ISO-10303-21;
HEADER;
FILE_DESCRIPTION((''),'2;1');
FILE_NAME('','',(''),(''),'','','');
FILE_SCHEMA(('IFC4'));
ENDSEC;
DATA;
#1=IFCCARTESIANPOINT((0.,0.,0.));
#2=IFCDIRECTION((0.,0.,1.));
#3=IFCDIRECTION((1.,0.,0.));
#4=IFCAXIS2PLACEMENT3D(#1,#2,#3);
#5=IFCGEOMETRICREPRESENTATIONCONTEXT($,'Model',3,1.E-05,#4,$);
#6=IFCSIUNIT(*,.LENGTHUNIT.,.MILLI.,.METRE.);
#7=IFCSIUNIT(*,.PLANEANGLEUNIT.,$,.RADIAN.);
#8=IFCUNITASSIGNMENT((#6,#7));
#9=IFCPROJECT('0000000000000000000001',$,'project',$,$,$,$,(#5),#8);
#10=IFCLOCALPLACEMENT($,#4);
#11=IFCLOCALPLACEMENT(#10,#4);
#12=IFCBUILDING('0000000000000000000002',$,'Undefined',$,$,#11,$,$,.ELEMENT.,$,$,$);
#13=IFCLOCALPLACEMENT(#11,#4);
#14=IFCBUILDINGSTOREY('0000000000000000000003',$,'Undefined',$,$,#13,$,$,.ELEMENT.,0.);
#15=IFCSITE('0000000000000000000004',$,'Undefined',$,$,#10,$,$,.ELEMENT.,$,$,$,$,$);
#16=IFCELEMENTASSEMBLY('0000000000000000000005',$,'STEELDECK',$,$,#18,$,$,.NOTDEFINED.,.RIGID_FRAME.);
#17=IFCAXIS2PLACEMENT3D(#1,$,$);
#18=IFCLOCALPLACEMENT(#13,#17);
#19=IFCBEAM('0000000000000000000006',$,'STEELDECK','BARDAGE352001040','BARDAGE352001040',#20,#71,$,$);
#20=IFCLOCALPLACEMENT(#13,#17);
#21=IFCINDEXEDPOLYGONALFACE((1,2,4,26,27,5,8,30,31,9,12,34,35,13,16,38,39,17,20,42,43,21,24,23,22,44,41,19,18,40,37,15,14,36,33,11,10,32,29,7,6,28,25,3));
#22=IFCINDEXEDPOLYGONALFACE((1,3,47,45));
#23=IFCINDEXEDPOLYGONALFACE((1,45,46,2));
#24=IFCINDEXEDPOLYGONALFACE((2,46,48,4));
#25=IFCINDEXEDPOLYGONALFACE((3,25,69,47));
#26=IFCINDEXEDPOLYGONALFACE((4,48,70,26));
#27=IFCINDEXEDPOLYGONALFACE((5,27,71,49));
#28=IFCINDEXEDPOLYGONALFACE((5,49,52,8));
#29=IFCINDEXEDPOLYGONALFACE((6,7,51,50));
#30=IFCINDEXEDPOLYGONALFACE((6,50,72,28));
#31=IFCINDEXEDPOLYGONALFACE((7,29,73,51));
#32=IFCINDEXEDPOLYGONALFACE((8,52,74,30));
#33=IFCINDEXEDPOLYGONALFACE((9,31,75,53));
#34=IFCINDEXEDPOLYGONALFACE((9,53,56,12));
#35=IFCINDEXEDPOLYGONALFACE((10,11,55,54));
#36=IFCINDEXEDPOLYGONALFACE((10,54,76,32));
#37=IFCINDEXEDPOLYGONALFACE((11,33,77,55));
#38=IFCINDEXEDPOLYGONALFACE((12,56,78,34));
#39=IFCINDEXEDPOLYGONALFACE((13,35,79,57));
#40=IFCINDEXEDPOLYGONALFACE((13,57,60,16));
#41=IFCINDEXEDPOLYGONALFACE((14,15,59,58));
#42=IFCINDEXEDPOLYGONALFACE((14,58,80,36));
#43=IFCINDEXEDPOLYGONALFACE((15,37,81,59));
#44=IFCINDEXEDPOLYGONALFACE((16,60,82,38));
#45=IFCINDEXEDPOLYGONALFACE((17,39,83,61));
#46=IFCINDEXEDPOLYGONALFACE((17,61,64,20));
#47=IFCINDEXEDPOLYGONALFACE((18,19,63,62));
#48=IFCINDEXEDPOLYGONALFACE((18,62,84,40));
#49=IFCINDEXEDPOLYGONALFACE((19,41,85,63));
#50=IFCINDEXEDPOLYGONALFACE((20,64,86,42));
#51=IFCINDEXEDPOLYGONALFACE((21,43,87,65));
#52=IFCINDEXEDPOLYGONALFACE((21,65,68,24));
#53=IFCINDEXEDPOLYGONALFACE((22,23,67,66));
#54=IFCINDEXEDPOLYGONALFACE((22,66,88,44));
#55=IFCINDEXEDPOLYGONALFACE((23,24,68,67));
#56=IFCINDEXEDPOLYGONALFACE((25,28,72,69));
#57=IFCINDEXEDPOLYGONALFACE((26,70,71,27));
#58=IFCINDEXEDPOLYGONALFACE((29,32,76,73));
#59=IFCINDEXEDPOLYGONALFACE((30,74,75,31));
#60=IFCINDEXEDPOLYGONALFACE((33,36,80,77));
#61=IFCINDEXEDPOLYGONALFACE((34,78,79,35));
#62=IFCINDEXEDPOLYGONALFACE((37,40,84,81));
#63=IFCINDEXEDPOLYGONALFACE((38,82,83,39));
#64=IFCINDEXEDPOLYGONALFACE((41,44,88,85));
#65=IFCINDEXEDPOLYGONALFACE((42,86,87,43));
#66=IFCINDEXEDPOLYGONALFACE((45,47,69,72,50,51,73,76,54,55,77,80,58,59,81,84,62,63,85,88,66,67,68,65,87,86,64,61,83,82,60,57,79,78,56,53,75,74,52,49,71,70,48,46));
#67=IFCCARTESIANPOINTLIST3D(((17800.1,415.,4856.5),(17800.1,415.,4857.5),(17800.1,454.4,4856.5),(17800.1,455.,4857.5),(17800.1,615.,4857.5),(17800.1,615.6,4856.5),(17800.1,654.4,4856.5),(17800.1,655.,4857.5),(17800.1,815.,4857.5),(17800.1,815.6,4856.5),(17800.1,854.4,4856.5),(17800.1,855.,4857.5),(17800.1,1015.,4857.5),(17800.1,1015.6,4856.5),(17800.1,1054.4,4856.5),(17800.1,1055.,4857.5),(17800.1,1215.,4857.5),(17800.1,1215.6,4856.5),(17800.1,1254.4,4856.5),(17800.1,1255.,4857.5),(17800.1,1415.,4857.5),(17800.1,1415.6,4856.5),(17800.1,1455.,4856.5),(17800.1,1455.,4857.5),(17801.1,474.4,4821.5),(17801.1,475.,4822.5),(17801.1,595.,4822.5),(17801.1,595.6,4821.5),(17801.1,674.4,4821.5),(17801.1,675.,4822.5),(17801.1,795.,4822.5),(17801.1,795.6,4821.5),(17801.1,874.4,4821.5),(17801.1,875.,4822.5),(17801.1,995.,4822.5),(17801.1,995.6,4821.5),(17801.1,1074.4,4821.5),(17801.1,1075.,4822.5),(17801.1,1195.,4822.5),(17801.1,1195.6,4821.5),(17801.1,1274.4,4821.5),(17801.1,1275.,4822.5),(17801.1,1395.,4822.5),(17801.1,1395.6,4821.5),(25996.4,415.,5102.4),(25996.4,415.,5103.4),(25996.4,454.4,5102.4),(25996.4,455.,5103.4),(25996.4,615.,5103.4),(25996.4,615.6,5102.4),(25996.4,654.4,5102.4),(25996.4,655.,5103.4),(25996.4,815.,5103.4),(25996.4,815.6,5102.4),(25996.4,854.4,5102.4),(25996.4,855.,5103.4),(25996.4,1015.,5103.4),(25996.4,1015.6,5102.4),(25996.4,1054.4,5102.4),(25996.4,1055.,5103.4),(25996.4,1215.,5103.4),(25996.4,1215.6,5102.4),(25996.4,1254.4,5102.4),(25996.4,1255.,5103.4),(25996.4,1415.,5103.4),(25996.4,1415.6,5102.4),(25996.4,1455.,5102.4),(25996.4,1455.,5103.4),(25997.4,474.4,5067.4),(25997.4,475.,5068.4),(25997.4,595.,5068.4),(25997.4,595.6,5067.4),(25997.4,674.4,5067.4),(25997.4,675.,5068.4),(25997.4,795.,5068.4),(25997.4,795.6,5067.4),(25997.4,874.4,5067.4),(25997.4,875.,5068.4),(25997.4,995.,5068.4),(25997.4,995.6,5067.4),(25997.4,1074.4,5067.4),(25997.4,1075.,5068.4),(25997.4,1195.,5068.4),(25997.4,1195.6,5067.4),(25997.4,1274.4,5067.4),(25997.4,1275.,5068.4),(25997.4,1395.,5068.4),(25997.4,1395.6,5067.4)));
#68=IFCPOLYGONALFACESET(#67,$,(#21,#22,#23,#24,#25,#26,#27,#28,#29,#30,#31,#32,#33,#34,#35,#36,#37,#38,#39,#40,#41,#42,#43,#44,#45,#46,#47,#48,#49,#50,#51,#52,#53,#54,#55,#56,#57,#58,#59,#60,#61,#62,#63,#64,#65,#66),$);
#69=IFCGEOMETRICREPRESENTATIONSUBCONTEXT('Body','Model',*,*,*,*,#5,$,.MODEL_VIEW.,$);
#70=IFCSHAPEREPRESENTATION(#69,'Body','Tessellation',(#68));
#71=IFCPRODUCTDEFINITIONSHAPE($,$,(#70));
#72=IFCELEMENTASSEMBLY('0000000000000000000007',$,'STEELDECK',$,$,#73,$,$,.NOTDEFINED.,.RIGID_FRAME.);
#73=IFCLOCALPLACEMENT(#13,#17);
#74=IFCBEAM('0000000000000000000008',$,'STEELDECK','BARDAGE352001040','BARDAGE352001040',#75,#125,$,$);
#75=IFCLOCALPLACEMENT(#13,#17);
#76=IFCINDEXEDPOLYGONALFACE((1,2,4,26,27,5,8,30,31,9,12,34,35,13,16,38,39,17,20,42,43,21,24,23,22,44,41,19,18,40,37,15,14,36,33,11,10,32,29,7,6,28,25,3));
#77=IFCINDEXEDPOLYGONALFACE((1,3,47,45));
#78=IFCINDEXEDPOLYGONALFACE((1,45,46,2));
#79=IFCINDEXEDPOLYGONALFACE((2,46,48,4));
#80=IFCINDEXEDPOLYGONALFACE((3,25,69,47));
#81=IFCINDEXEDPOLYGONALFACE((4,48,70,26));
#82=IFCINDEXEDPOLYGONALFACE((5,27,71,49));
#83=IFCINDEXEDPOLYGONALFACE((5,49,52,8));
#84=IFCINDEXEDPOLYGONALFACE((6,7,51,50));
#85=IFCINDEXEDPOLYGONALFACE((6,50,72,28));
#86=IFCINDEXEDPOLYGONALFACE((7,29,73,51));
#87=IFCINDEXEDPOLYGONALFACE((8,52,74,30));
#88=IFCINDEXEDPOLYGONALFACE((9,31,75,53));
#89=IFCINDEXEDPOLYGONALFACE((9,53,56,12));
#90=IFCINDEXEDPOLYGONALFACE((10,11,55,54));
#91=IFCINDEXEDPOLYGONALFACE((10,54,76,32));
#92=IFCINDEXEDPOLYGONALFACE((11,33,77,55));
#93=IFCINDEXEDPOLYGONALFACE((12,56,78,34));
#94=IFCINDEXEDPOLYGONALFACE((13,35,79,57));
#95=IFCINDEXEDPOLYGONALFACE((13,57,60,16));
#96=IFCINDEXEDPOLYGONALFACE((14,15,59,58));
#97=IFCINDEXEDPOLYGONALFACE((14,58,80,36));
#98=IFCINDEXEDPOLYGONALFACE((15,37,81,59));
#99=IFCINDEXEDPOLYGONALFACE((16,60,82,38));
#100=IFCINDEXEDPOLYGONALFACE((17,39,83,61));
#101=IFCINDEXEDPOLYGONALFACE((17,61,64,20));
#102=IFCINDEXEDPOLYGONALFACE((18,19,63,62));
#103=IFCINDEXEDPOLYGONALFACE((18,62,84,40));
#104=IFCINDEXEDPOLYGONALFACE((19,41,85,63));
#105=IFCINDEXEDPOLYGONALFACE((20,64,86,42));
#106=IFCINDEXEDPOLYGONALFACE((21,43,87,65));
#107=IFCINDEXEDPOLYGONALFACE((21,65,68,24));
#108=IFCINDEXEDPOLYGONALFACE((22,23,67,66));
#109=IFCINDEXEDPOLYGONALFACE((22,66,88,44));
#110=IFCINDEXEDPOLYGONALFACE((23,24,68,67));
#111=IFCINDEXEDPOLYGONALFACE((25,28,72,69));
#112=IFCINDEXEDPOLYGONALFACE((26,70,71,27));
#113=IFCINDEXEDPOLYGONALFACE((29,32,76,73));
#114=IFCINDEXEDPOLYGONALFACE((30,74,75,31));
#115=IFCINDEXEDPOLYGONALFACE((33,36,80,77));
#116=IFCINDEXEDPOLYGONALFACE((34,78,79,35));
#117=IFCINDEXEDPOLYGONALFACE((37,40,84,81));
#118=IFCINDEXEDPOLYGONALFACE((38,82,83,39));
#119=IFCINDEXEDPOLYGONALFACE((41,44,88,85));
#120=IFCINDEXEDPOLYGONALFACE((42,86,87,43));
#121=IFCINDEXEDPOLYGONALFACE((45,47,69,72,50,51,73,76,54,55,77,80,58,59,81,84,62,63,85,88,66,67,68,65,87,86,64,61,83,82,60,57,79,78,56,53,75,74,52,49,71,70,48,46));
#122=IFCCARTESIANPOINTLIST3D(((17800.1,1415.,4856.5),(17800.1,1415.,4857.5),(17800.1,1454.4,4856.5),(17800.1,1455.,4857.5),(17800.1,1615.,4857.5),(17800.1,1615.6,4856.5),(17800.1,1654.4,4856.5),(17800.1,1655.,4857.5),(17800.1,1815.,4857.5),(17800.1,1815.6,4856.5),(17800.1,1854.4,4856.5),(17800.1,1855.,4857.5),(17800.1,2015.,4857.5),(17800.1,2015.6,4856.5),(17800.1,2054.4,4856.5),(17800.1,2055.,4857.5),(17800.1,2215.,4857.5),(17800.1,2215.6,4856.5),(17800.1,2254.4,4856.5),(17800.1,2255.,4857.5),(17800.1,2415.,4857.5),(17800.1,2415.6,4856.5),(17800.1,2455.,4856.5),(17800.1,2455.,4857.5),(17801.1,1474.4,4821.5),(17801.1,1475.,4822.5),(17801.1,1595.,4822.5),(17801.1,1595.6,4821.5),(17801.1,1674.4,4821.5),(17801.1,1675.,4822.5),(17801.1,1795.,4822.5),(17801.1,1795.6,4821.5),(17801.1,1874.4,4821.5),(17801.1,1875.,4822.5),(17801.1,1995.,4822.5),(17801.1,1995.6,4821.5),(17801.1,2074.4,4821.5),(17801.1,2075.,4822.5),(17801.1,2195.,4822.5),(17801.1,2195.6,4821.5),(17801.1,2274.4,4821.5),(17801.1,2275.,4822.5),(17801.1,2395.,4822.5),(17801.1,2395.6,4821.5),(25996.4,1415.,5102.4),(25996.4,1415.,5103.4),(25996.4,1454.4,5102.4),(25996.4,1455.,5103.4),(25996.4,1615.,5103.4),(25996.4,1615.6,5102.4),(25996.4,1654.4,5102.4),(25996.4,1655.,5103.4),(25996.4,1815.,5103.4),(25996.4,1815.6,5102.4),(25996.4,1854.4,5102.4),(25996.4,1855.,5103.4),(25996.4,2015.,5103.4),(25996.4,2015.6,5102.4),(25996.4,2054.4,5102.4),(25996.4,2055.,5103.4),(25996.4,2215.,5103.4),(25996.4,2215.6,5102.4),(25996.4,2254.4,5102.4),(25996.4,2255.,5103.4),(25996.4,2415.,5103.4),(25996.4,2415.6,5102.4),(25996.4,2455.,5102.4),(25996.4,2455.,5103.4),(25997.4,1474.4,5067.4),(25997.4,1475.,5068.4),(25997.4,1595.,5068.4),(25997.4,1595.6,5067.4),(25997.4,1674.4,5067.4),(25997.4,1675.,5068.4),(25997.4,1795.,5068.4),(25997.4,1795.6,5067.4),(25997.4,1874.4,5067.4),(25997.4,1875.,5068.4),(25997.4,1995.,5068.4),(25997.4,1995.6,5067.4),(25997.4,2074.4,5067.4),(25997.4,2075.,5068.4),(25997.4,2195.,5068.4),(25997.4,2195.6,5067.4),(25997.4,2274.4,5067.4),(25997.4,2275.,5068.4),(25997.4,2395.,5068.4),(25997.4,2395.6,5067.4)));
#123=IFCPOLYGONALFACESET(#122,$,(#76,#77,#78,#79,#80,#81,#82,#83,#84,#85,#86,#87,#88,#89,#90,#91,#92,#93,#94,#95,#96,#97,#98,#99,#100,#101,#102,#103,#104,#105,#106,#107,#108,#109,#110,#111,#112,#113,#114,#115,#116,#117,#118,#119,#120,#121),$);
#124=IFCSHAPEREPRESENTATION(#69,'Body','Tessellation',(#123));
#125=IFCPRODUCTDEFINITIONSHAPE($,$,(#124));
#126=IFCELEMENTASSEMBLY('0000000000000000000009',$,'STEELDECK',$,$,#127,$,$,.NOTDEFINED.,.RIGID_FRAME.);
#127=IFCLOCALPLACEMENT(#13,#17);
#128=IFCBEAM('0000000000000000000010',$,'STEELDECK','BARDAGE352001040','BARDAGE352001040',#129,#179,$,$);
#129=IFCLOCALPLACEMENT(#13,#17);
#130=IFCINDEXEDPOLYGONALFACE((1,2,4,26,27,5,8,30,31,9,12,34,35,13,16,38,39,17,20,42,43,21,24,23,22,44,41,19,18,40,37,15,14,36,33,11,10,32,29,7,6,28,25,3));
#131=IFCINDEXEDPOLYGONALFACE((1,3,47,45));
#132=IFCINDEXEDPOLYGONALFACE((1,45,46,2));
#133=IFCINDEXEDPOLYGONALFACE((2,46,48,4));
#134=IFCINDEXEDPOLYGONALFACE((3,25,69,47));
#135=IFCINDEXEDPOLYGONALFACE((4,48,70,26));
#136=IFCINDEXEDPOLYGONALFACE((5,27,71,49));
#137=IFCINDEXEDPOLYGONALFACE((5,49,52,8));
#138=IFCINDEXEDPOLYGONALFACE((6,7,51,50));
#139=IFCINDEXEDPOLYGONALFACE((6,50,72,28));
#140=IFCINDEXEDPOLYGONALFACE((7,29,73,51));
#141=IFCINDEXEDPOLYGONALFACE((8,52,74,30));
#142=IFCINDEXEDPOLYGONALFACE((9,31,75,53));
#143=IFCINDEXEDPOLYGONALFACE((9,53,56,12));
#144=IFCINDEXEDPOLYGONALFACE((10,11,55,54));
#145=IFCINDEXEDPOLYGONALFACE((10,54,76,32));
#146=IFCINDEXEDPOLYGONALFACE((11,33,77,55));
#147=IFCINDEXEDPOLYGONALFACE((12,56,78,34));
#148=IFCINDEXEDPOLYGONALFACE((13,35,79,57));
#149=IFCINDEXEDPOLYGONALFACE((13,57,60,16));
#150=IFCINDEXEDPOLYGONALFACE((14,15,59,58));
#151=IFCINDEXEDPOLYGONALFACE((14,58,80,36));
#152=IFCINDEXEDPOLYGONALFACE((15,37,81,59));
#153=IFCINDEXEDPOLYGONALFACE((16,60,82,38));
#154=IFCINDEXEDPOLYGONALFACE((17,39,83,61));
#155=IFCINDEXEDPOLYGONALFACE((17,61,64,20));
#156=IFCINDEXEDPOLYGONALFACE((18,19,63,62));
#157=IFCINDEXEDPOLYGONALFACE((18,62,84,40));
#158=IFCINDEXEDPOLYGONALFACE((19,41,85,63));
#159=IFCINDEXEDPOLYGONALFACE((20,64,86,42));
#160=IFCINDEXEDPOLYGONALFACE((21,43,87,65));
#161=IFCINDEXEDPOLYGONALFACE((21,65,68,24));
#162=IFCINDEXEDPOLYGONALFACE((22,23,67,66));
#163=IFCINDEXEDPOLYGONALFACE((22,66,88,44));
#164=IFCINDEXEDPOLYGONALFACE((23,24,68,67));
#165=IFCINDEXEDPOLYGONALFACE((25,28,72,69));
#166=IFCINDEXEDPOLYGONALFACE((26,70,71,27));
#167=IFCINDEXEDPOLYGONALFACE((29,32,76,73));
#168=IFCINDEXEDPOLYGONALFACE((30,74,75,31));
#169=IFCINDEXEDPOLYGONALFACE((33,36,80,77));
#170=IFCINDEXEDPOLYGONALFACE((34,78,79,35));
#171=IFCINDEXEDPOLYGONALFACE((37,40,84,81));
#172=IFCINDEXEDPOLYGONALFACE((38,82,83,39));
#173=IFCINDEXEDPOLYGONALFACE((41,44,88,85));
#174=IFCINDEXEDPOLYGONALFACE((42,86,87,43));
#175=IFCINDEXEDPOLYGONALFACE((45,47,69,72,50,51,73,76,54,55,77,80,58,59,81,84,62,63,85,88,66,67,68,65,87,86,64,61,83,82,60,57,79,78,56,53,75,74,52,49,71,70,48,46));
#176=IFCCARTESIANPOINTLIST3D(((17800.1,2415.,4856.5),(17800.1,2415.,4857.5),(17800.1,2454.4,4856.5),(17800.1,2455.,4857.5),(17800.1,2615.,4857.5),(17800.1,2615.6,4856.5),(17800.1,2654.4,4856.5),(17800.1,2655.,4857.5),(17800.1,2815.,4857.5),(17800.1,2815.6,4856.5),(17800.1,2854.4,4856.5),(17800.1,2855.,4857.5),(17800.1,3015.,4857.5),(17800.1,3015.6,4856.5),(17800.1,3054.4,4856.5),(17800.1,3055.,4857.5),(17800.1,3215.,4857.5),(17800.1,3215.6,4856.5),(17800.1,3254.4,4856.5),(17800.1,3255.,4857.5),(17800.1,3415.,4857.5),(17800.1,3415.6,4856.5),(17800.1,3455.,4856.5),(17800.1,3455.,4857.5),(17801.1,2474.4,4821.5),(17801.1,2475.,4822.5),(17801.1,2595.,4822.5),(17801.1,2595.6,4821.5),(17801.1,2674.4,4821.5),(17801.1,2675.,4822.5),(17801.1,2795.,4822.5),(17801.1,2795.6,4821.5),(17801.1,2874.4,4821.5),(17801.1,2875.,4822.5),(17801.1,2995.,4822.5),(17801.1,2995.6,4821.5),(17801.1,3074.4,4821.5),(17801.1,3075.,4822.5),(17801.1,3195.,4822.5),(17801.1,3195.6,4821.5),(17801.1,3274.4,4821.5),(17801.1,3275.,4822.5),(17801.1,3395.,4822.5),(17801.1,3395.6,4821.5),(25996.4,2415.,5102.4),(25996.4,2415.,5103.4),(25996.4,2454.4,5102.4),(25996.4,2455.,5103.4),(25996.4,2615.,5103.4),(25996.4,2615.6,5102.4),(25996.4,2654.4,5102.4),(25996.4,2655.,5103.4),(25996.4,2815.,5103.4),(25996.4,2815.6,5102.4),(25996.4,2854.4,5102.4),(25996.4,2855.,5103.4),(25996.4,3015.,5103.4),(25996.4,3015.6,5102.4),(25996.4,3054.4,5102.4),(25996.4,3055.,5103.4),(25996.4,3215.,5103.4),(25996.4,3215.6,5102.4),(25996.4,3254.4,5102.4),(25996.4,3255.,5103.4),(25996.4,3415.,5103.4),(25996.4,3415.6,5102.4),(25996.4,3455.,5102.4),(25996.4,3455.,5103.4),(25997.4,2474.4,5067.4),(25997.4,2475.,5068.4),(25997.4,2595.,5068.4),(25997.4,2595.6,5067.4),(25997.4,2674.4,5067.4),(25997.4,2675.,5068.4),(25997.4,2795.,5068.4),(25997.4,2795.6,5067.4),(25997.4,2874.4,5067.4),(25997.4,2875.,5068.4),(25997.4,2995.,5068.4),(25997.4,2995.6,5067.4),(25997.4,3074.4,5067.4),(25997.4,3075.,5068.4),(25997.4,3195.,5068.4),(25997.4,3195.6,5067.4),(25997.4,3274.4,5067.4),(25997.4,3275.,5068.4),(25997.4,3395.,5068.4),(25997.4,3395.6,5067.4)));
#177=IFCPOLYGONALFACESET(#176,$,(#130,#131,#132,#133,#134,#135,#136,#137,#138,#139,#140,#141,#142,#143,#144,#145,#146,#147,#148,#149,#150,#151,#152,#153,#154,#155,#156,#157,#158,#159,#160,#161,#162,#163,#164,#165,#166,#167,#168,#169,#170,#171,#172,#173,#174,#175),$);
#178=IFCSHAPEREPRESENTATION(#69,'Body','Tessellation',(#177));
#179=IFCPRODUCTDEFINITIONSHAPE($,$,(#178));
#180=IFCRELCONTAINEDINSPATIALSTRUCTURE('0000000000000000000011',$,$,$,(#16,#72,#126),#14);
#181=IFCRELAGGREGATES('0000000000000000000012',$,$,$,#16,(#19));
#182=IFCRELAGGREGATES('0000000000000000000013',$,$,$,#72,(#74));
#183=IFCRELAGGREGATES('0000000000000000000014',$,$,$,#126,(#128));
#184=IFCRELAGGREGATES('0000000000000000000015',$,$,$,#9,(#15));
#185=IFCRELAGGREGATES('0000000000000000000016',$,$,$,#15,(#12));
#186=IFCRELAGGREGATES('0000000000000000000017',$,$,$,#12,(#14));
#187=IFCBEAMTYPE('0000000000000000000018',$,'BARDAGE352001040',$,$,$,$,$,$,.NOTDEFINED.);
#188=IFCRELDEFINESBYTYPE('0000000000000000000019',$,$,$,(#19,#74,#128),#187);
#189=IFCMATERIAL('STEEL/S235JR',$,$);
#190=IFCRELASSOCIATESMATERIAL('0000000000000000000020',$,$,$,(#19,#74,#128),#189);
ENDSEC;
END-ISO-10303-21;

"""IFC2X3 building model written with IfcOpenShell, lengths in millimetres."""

from ifc_helpers import new_model, si_unit, frame, origin_with_axes, place, context, subcontext, project, spatial, polyline, outline, extrude, material, type_object, element, aggregate, save


model = new_model("IFC2X3")

# Units and contexts
model_context = context("Model", 3, precision=1e-05, world=origin_with_axes())
body_context = subcontext(model_context, "Body", "Model", "MODEL_VIEW")
ifc_project = project(units=[si_unit("LENGTHUNIT", "METRE", prefix="MILLI"), si_unit("PLANEANGLEUNIT", "RADIAN")], contexts=[model_context])

# Site, building, storey
site_placement = place(None, origin_with_axes())
site = spatial("IfcSite", under=ifc_project, at=site_placement, Name="Undefined", CompositionType="ELEMENT")
building_placement = place(site_placement, origin_with_axes())
building = spatial("IfcBuilding", under=site, at=building_placement, Name="Undefined", CompositionType="ELEMENT")
storey_placement = place(building_placement, origin_with_axes())
storey = spatial("IfcBuildingStorey", under=building, at=storey_placement, Name="Undefined", CompositionType="ELEMENT", Elevation=0.0)

# Element assemblies, beams
ifc_material_1 = material(Name="STEEL/S235JR")
beam_type_1 = type_object("IfcBeamType", Name="BARDAGE352001040", PredefinedType="NOTDEFINED")
assembly_1_placement = place(storey_placement, origin_with_axes())
assembly_1 = element("IfcElementAssembly", 1, at=assembly_1_placement, inside=storey, Name="STEELDECK", AssemblyPlace="NOTDEFINED", PredefinedType="RIGID_FRAME")
beam_1_placement = place(assembly_1_placement, frame((17800.1, 1455.0, 4857.5), z_axis=(-0.029987, 0.0, 0.99955), x_axis=(0.99955, 0.0, 0.029986)))
beam_1 = element("IfcBeam", 2, at=beam_1_placement, type_object=beam_type_1, material=ifc_material_1, Name="STEELDECK", Description="BARDAGE352001040", ObjectType="BARDAGE352001040", context=body_context, shape_type="SweptSolid", body=[
    extrude(outline(polyline([(200.6, -1.0), (180.6, -36.0), (59.4, -36.0), (39.4, -1.0), (0.0, -1.0), (0.0, 0.0), (40.0, 0.0), (60.0, -35.0), (180.0, -35.0), (200.0, 0.0), (240.0, 0.0), (260.0, -35.0), (380.0, -35.0), (400.0, 0.0), (440.0, 0.0), (460.0, -35.0), (580.0, -35.0), (600.0, 0.0), (640.0, 0.0), (660.0, -35.0), (780.0, -35.0), (800.0, 0.0), (840.0, 0.0), (860.0, -35.0), (980.0, -35.0), (1000.0, 0.0), (1040.0, 0.0), (1040.0, -1.0), (1000.6, -1.0), (980.6, -36.0), (859.4, -36.0), (839.4, -1.0), (800.6, -1.0), (780.6, -36.0), (659.4, -36.0), (639.4, -1.0), (600.6, -1.0), (580.6, -36.0), (459.4, -36.0), (439.4, -1.0), (400.6, -1.0), (380.6, -36.0), (259.4, -36.0), (239.4, -1.0), (200.6, -1.0)])), frame((8200.0, 0.0, 0.0), z_axis=(-1.0, 0.0, 0.0), x_axis=(0.0, -1.0, 0.0)), (0.0, 0.0, 1.0), 8200.0),
])
aggregate(assembly_1, [beam_1])
assembly_2_placement = place(storey_placement, origin_with_axes())
assembly_2 = element("IfcElementAssembly", 3, at=assembly_2_placement, inside=storey, Name="STEELDECK", AssemblyPlace="NOTDEFINED", PredefinedType="RIGID_FRAME")
beam_2_placement = place(assembly_2_placement, frame((17800.1, 2455.0, 4857.5), z_axis=(-0.029987, 0.0, 0.99955), x_axis=(0.99955, 0.0, 0.029986)))
beam_2 = element("IfcBeam", 4, at=beam_2_placement, type_object=beam_type_1, material=ifc_material_1, Name="STEELDECK", Description="BARDAGE352001040", ObjectType="BARDAGE352001040", context=body_context, shape_type="SweptSolid", body=[
    extrude(outline(polyline([(200.6, -1.0), (180.6, -36.0), (59.4, -36.0), (39.4, -1.0), (0.0, -1.0), (0.0, 0.0), (40.0, 0.0), (60.0, -35.0), (180.0, -35.0), (200.0, 0.0), (240.0, 0.0), (260.0, -35.0), (380.0, -35.0), (400.0, 0.0), (440.0, 0.0), (460.0, -35.0), (580.0, -35.0), (600.0, 0.0), (640.0, 0.0), (660.0, -35.0), (780.0, -35.0), (800.0, 0.0), (840.0, 0.0), (860.0, -35.0), (980.0, -35.0), (1000.0, 0.0), (1040.0, 0.0), (1040.0, -1.0), (1000.6, -1.0), (980.6, -36.0), (859.4, -36.0), (839.4, -1.0), (800.6, -1.0), (780.6, -36.0), (659.4, -36.0), (639.4, -1.0), (600.6, -1.0), (580.6, -36.0), (459.4, -36.0), (439.4, -1.0), (400.6, -1.0), (380.6, -36.0), (259.4, -36.0), (239.4, -1.0), (200.6, -1.0)])), frame((8200.0, 0.0, 0.0), z_axis=(-1.0, 0.0, 0.0), x_axis=(0.0, -1.0, 0.0)), (0.0, 0.0, 1.0), 8200.0),
])
aggregate(assembly_2, [beam_2])
assembly_3_placement = place(storey_placement, origin_with_axes())
assembly_3 = element("IfcElementAssembly", 5, at=assembly_3_placement, inside=storey, Name="STEELDECK", AssemblyPlace="NOTDEFINED", PredefinedType="RIGID_FRAME")
beam_3_placement = place(assembly_3_placement, frame((17800.1, 3455.0, 4857.5), z_axis=(-0.029987, 0.0, 0.99955), x_axis=(0.99955, 0.0, 0.029986)))
beam_3 = element("IfcBeam", 6, at=beam_3_placement, type_object=beam_type_1, material=ifc_material_1, Name="STEELDECK", Description="BARDAGE352001040", ObjectType="BARDAGE352001040", context=body_context, shape_type="SweptSolid", body=[
    extrude(outline(polyline([(200.6, -1.0), (180.6, -36.0), (59.4, -36.0), (39.4, -1.0), (0.0, -1.0), (0.0, 0.0), (40.0, 0.0), (60.0, -35.0), (180.0, -35.0), (200.0, 0.0), (240.0, 0.0), (260.0, -35.0), (380.0, -35.0), (400.0, 0.0), (440.0, 0.0), (460.0, -35.0), (580.0, -35.0), (600.0, 0.0), (640.0, 0.0), (660.0, -35.0), (780.0, -35.0), (800.0, 0.0), (840.0, 0.0), (860.0, -35.0), (980.0, -35.0), (1000.0, 0.0), (1040.0, 0.0), (1040.0, -1.0), (1000.6, -1.0), (980.6, -36.0), (859.4, -36.0), (839.4, -1.0), (800.6, -1.0), (780.6, -36.0), (659.4, -36.0), (639.4, -1.0), (600.6, -1.0), (580.6, -36.0), (459.4, -36.0), (439.4, -1.0), (400.6, -1.0), (380.6, -36.0), (259.4, -36.0), (239.4, -1.0), (200.6, -1.0)])), frame((8200.0, 0.0, 0.0), z_axis=(-1.0, 0.0, 0.0), x_axis=(0.0, -1.0, 0.0)), (0.0, 0.0, 1.0), 8200.0),
])
aggregate(assembly_3, [beam_3])

save(model, "model.ifc")
